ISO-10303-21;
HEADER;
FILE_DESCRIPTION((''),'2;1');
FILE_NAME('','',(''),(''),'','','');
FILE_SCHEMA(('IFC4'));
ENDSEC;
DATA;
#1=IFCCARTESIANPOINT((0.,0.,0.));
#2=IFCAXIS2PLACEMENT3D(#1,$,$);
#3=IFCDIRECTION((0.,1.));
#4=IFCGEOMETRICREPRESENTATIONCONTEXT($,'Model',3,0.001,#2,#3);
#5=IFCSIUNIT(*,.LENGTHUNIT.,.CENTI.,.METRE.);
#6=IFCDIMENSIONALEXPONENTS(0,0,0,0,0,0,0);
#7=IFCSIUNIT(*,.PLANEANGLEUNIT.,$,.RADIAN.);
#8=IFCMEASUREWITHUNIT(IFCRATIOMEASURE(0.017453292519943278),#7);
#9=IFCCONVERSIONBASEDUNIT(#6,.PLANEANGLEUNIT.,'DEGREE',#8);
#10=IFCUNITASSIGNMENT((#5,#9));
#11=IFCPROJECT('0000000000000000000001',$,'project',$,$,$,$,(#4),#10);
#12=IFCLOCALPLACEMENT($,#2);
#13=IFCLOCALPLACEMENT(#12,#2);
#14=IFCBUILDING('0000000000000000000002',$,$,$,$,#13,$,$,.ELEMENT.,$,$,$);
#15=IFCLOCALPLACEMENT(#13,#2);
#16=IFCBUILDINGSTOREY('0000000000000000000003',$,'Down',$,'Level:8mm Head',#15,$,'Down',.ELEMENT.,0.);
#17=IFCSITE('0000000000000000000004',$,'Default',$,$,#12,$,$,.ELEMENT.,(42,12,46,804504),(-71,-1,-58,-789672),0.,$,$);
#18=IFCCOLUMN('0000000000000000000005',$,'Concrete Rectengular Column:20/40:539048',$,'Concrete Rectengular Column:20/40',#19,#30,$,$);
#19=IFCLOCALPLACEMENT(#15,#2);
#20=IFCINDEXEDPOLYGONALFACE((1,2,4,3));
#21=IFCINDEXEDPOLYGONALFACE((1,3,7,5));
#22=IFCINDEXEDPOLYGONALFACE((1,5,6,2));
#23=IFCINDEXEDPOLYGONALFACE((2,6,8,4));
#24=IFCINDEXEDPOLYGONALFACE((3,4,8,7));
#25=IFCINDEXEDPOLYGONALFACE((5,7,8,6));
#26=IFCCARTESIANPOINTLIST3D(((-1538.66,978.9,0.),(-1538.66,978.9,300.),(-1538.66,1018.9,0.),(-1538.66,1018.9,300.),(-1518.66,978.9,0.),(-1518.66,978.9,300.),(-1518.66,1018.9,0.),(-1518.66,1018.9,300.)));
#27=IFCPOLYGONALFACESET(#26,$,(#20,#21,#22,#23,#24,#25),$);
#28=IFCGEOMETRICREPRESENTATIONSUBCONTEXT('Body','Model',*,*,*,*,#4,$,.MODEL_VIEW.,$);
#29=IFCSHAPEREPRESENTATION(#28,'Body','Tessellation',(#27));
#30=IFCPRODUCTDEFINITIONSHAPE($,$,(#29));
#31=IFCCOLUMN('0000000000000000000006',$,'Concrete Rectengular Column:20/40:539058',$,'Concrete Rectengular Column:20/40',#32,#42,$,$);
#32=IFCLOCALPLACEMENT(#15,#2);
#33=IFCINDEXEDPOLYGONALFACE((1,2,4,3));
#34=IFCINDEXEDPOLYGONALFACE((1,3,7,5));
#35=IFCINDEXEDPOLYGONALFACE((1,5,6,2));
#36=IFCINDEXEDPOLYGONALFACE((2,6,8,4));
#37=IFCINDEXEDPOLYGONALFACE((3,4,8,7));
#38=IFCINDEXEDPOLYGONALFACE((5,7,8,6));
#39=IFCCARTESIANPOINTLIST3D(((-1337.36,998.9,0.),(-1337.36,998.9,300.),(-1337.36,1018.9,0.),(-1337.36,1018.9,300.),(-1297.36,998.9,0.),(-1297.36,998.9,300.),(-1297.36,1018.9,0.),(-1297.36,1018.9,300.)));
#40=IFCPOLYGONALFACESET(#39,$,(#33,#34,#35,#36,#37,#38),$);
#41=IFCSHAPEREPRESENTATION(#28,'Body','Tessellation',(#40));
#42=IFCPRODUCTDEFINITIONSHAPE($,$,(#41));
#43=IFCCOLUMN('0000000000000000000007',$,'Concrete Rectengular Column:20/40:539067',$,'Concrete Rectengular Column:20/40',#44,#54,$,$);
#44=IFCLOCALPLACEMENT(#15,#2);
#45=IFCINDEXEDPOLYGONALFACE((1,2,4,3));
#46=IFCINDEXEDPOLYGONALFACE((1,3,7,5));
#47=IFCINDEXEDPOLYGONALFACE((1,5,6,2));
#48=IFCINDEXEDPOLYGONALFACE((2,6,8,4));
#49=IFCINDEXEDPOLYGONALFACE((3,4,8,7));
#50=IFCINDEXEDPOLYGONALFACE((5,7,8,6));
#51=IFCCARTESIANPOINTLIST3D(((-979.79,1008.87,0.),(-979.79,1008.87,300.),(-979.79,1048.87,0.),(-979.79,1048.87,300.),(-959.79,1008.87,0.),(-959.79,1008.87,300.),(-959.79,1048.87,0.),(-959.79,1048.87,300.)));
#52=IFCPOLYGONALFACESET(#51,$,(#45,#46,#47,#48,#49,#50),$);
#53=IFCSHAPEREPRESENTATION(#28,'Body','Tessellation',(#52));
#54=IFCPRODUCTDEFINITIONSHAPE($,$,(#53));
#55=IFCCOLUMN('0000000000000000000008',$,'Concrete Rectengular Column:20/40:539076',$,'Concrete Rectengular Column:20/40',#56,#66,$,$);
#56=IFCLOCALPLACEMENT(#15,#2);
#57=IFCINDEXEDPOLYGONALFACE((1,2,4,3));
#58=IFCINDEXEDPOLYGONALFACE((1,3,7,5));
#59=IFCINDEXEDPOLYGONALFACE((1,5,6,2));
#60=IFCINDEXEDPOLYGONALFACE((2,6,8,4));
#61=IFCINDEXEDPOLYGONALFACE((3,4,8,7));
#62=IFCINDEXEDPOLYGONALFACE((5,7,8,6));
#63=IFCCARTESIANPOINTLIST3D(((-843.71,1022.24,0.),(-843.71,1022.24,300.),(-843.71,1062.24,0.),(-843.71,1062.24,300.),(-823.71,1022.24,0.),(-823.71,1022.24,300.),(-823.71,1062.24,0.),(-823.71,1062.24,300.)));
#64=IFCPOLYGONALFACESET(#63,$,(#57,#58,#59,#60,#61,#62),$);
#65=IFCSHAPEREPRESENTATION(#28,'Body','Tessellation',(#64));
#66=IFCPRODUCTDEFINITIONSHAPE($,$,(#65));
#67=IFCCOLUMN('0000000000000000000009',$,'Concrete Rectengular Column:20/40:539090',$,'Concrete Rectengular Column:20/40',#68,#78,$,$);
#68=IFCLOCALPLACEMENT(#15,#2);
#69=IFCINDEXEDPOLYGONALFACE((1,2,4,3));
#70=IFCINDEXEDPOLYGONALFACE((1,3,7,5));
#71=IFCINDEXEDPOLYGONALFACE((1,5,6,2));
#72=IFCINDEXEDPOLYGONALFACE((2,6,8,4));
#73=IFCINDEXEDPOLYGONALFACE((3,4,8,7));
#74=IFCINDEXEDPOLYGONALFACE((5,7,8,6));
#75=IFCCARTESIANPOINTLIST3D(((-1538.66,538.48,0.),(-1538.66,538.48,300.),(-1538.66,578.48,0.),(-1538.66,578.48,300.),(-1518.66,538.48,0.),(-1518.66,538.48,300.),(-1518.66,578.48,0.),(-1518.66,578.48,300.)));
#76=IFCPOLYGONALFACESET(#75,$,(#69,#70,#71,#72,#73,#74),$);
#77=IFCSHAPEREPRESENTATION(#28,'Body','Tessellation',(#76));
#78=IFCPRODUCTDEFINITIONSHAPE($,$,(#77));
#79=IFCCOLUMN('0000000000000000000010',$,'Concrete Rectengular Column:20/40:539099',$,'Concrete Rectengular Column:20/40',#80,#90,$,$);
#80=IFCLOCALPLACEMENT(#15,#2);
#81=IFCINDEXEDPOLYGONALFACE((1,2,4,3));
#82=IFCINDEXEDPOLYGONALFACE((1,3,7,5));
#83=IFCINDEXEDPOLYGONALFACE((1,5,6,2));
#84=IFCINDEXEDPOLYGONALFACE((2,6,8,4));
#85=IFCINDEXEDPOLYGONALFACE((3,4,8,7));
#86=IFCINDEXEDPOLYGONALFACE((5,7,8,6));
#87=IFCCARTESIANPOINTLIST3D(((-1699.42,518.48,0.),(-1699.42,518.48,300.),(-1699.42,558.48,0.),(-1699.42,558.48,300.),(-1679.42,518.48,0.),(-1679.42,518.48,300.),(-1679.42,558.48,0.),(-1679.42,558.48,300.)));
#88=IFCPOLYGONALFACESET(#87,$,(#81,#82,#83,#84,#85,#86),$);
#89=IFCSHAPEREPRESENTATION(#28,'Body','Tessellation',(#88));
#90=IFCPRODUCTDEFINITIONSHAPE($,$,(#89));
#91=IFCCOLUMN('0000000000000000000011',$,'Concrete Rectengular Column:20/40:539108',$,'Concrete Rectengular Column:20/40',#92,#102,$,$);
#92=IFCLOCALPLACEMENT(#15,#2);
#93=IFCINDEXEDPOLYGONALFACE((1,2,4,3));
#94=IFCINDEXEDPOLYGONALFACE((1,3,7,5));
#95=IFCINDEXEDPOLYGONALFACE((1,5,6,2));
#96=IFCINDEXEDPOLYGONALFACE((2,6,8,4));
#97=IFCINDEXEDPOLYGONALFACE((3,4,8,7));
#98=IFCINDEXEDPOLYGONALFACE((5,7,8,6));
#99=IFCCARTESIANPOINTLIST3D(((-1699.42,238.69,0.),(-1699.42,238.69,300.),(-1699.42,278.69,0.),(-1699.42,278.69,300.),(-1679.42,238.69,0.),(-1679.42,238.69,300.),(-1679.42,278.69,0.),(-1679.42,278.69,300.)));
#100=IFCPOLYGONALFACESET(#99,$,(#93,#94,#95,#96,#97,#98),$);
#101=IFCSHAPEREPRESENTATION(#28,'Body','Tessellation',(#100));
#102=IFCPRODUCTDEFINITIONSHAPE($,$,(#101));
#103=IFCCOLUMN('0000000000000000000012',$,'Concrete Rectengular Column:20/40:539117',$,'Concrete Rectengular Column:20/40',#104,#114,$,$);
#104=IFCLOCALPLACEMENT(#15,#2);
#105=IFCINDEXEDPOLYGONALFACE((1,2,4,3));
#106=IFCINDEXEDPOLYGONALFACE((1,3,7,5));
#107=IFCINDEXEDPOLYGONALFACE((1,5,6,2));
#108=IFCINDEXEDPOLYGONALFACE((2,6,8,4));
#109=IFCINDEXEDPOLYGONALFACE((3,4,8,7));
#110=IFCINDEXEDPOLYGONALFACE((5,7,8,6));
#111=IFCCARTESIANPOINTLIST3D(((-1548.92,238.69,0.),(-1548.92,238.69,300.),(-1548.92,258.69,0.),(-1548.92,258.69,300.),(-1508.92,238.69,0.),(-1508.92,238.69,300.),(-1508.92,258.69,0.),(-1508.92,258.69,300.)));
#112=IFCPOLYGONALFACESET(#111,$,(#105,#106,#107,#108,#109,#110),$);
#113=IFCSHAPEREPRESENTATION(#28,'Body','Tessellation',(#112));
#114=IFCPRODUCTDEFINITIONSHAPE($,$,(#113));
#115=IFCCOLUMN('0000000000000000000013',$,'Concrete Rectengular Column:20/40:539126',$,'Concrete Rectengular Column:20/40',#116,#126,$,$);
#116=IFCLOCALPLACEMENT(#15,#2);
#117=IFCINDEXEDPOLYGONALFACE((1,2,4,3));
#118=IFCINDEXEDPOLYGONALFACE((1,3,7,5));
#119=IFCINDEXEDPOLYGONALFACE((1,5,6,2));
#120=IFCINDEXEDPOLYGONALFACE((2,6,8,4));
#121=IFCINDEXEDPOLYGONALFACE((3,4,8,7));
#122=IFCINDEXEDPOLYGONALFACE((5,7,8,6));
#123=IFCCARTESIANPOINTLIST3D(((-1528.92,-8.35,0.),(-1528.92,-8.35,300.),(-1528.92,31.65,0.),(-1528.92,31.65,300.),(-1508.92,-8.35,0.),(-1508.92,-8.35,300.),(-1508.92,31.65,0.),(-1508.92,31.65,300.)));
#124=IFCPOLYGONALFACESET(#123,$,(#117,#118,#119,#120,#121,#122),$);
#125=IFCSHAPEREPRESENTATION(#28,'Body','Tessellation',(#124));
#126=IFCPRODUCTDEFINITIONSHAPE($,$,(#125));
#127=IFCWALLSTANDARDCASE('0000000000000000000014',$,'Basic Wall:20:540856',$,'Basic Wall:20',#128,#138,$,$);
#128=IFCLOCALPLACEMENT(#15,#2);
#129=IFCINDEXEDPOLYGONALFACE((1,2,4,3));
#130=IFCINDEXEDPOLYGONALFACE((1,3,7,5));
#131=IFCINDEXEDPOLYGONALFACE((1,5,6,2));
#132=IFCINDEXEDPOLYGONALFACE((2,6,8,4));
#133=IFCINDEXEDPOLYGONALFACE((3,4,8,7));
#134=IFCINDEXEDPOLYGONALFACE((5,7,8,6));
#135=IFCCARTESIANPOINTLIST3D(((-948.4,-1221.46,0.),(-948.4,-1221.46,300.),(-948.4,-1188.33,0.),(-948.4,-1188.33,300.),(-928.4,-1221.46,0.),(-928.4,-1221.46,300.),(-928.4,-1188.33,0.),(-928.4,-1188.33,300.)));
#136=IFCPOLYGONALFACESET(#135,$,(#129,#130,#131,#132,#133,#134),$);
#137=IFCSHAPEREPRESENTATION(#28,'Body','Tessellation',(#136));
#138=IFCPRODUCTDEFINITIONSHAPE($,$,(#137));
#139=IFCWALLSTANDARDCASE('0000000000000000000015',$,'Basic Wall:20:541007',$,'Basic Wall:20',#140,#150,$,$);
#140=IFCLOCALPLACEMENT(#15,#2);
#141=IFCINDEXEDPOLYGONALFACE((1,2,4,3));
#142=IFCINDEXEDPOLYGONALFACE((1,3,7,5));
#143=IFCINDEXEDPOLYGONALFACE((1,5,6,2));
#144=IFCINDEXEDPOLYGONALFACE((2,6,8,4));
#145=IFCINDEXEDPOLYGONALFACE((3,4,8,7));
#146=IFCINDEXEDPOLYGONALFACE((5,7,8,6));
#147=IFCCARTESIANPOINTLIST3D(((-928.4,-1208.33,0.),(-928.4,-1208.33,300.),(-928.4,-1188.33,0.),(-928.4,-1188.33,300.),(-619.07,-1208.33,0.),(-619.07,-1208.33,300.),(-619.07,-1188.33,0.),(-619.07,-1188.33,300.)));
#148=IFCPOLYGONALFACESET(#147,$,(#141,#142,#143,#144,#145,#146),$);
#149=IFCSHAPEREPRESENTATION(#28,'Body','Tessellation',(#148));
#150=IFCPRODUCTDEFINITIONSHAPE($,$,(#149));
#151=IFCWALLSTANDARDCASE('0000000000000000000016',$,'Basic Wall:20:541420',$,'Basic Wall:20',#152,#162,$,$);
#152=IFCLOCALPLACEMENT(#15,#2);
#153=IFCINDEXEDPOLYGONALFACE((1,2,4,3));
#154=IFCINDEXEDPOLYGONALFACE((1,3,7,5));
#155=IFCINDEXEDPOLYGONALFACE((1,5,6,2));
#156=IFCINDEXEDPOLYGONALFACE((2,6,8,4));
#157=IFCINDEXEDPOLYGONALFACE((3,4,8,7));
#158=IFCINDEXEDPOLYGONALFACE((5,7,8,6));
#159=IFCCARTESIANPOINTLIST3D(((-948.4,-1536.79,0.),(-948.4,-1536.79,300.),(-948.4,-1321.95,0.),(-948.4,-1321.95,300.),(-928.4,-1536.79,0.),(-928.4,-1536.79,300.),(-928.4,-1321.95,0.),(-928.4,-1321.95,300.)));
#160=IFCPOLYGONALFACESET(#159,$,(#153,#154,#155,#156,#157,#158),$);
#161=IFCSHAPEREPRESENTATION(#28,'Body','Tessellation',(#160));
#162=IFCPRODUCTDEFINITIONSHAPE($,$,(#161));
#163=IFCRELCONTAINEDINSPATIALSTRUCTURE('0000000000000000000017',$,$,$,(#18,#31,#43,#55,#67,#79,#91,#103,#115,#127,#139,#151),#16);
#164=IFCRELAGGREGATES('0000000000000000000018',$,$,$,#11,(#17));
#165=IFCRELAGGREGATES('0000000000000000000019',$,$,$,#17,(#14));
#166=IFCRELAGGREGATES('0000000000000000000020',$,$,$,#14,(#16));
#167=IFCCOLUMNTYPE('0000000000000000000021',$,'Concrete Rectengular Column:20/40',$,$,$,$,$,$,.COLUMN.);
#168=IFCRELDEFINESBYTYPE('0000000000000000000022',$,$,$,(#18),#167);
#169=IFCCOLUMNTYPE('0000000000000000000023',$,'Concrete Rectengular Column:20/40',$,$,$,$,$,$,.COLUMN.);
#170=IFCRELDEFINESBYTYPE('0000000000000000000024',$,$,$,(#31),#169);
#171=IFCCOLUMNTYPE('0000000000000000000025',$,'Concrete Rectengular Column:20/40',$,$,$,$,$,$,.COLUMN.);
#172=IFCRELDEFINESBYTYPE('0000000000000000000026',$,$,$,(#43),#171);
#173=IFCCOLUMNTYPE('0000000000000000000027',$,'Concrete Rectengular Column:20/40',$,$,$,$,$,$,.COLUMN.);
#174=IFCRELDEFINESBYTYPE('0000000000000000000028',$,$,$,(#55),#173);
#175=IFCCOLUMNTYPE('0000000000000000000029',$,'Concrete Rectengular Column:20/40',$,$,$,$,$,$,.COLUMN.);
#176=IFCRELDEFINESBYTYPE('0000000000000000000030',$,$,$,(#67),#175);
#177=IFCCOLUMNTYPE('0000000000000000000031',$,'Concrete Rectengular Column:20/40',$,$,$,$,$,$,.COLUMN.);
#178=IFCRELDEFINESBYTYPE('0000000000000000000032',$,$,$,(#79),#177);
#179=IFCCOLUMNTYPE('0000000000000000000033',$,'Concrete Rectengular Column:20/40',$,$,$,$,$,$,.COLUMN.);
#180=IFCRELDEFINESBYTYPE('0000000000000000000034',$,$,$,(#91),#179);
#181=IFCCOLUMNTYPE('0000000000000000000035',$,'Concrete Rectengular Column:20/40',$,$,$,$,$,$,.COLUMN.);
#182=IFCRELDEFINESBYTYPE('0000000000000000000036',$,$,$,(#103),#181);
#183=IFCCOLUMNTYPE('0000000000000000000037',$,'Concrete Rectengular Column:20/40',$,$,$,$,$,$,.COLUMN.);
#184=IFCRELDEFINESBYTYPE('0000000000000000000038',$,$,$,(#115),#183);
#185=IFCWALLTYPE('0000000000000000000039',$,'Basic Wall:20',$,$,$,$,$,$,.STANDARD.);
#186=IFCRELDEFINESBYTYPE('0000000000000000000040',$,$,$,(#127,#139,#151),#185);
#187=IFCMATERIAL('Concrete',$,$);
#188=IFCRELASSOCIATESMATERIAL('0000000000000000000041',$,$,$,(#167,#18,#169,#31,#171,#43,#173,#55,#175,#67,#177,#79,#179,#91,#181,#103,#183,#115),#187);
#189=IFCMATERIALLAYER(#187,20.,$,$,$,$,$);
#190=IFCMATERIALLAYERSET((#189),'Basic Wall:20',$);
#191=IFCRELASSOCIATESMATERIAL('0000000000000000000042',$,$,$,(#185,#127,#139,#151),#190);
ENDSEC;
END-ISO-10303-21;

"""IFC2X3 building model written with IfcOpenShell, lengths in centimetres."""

from ifc_helpers import new_model, entity, si_unit, converted_unit, direction, frame, frame_2d, origin, origin_2d_with_axis, place, context, subcontext, project, spatial, rectangle, extrude, source, transform, mapped, material, layer, layer_set, layer_usage, type_object, type_shapes, element, save


model = new_model("IFC2X3")

# Units and contexts
model_context = context("Model", 3, precision=0.001, world=origin(), true_north=direction((0.0, 1.0)))
body_context = subcontext(model_context, "Body", "Model", "MODEL_VIEW")
ifc_project = project(units=[si_unit("LENGTHUNIT", "METRE", prefix="CENTI"), converted_unit("PLANEANGLEUNIT", "DEGREE", entity("IfcRatioMeasure", 0.017453292519943278), si_unit("PLANEANGLEUNIT", "RADIAN"), dimensions=[0, 0, 0, 0, 0, 0, 0])], contexts=[model_context])

# Site, building, storey
site_placement = place(None, origin())
site = spatial("IfcSite", under=ifc_project, at=site_placement, Name="Default", CompositionType="ELEMENT", RefLatitude=(42, 12, 46, 804504), RefLongitude=(-71, -1, -58, -789672), RefElevation=0.0)
building_placement = place(site_placement, origin())
building = spatial("IfcBuilding", under=site, at=building_placement, CompositionType="ELEMENT")
storey_placement = place(building_placement, origin())
storey = spatial("IfcBuildingStorey", under=building, at=storey_placement, Name="Down", ObjectType="Level:8mm Head", LongName="Down", CompositionType="ELEMENT", Elevation=0.0)

# Columns
ifc_material = material(Name="Concrete")
column_type_1 = type_object("IfcColumnType", Name="Concrete Rectengular Column:20/40", PredefinedType="COLUMN", material=ifc_material)
shared_shape_1 = source(origin(), body_context, "Body", "SweptSolid", [
    extrude(rectangle(XDim=40.0, YDim=20.0, at=frame_2d((0.0, 0.0), x_axis=(1.0, 0.0))), frame((-1528.66, 998.9, 0.0), z_axis=(0.0, 0.0, 1.0), x_axis=(0.0, -1.0, 0.0)), (0.0, 0.0, 1.0), 300.0),
])
type_shapes(column_type_1, [shared_shape_1])
column_1_placement = place(storey_placement, origin())
element("IfcColumn", 1, at=column_1_placement, inside=storey, type_object=column_type_1, material=ifc_material, Name="Concrete Rectengular Column:20/40:539048", ObjectType="Concrete Rectengular Column:20/40", context=body_context, shape_type="MappedRepresentation", body=[
    mapped(shared_shape_1, transform((0.0, 0.0, 0.0), scale=1.0)),
])
column_type_2 = type_object("IfcColumnType", Name="Concrete Rectengular Column:20/40", PredefinedType="COLUMN", material=ifc_material)
shared_shape_2 = source(origin(), body_context, "Body", "SweptSolid", [
    extrude(rectangle(XDim=20.0, YDim=40.0, at=frame_2d((0.0, 0.0), x_axis=(1.0, 0.0))), frame((-1317.36, 1008.9, 0.0), z_axis=(0.0, 0.0, 1.0), x_axis=(0.0, -1.0, 0.0)), (0.0, 0.0, 1.0), 300.0),
])
type_shapes(column_type_2, [shared_shape_2])
column_2_placement = place(storey_placement, origin())
element("IfcColumn", 2, at=column_2_placement, inside=storey, type_object=column_type_2, material=ifc_material, Name="Concrete Rectengular Column:20/40:539058", ObjectType="Concrete Rectengular Column:20/40", context=body_context, shape_type="MappedRepresentation", body=[
    mapped(shared_shape_2, transform((0.0, 0.0, 0.0), scale=1.0)),
])
column_type_3 = type_object("IfcColumnType", Name="Concrete Rectengular Column:20/40", PredefinedType="COLUMN", material=ifc_material)
shared_shape_3 = source(origin(), body_context, "Body", "SweptSolid", [
    extrude(rectangle(XDim=40.0, YDim=20.0, at=frame_2d((0.0, 0.0), x_axis=(1.0, 0.0))), frame((-969.79, 1028.87, 0.0), z_axis=(0.0, 0.0, 1.0), x_axis=(0.0, -1.0, 0.0)), (0.0, 0.0, 1.0), 300.0),
])
type_shapes(column_type_3, [shared_shape_3])
column_3_placement = place(storey_placement, origin())
element("IfcColumn", 3, at=column_3_placement, inside=storey, type_object=column_type_3, material=ifc_material, Name="Concrete Rectengular Column:20/40:539067", ObjectType="Concrete Rectengular Column:20/40", context=body_context, shape_type="MappedRepresentation", body=[
    mapped(shared_shape_3, transform((0.0, 0.0, 0.0), scale=1.0)),
])
column_type_4 = type_object("IfcColumnType", Name="Concrete Rectengular Column:20/40", PredefinedType="COLUMN", material=ifc_material)
shared_shape_4 = source(origin(), body_context, "Body", "SweptSolid", [
    extrude(rectangle(XDim=40.0, YDim=20.0, at=origin_2d_with_axis()), frame((-833.71, 1042.24, 0.0), z_axis=(0.0, 0.0, 1.0), x_axis=(0.0, -1.0, 0.0)), (0.0, 0.0, 1.0), 300.0),
])
type_shapes(column_type_4, [shared_shape_4])
column_4_placement = place(storey_placement, origin())
element("IfcColumn", 4, at=column_4_placement, inside=storey, type_object=column_type_4, material=ifc_material, Name="Concrete Rectengular Column:20/40:539076", ObjectType="Concrete Rectengular Column:20/40", context=body_context, shape_type="MappedRepresentation", body=[
    mapped(shared_shape_4, transform((0.0, 0.0, 0.0), scale=1.0)),
])
column_type_5 = type_object("IfcColumnType", Name="Concrete Rectengular Column:20/40", PredefinedType="COLUMN", material=ifc_material)
shared_shape_5 = source(origin(), body_context, "Body", "SweptSolid", [
    extrude(rectangle(XDim=40.0, YDim=20.0, at=frame_2d((0.0, 0.0), x_axis=(1.0, 0.0))), frame((-1528.66, 558.48, 0.0), z_axis=(0.0, 0.0, 1.0), x_axis=(0.0, -1.0, 0.0)), (0.0, 0.0, 1.0), 300.0),
])
type_shapes(column_type_5, [shared_shape_5])
column_5_placement = place(storey_placement, origin())
element("IfcColumn", 5, at=column_5_placement, inside=storey, type_object=column_type_5, material=ifc_material, Name="Concrete Rectengular Column:20/40:539090", ObjectType="Concrete Rectengular Column:20/40", context=body_context, shape_type="MappedRepresentation", body=[
    mapped(shared_shape_5, transform((0.0, 0.0, 0.0), scale=1.0)),
])
column_type_6 = type_object("IfcColumnType", Name="Concrete Rectengular Column:20/40", PredefinedType="COLUMN", material=ifc_material)
shared_shape_6 = source(origin(), body_context, "Body", "SweptSolid", [
    extrude(rectangle(XDim=40.0, YDim=20.0, at=frame_2d((0.0, 0.0), x_axis=(1.0, 0.0))), frame((-1689.42, 538.48, 0.0), z_axis=(0.0, 0.0, 1.0), x_axis=(0.0, -1.0, 0.0)), (0.0, 0.0, 1.0), 300.0),
])
type_shapes(column_type_6, [shared_shape_6])
column_6_placement = place(storey_placement, origin())
element("IfcColumn", 6, at=column_6_placement, inside=storey, type_object=column_type_6, material=ifc_material, Name="Concrete Rectengular Column:20/40:539099", ObjectType="Concrete Rectengular Column:20/40", context=body_context, shape_type="MappedRepresentation", body=[
    mapped(shared_shape_6, transform((0.0, 0.0, 0.0), scale=1.0)),
])
column_type_7 = type_object("IfcColumnType", Name="Concrete Rectengular Column:20/40", PredefinedType="COLUMN", material=ifc_material)
shared_shape_7 = source(origin(), body_context, "Body", "SweptSolid", [
    extrude(rectangle(XDim=40.0, YDim=20.0, at=frame_2d((0.0, 0.0), x_axis=(1.0, 0.0))), frame((-1689.42, 258.69, 0.0), z_axis=(0.0, 0.0, 1.0), x_axis=(0.0, -1.0, 0.0)), (0.0, 0.0, 1.0), 300.0),
])
type_shapes(column_type_7, [shared_shape_7])
column_7_placement = place(storey_placement, origin())
element("IfcColumn", 7, at=column_7_placement, inside=storey, type_object=column_type_7, material=ifc_material, Name="Concrete Rectengular Column:20/40:539108", ObjectType="Concrete Rectengular Column:20/40", context=body_context, shape_type="MappedRepresentation", body=[
    mapped(shared_shape_7, transform((0.0, 0.0, 0.0), scale=1.0)),
])
column_type_8 = type_object("IfcColumnType", Name="Concrete Rectengular Column:20/40", PredefinedType="COLUMN", material=ifc_material)
shared_shape_8 = source(origin(), body_context, "Body", "SweptSolid", [
    extrude(rectangle(XDim=20.0, YDim=40.0, at=frame_2d((0.0, 0.0), x_axis=(1.0, 0.0))), frame((-1528.92, 248.69, 0.0), z_axis=(0.0, 0.0, 1.0), x_axis=(0.0, -1.0, 0.0)), (0.0, 0.0, 1.0), 300.0),
])
type_shapes(column_type_8, [shared_shape_8])
column_8_placement = place(storey_placement, origin())
element("IfcColumn", 8, at=column_8_placement, inside=storey, type_object=column_type_8, material=ifc_material, Name="Concrete Rectengular Column:20/40:539117", ObjectType="Concrete Rectengular Column:20/40", context=body_context, shape_type="MappedRepresentation", body=[
    mapped(shared_shape_8, transform((0.0, 0.0, 0.0), scale=1.0)),
])
column_type_9 = type_object("IfcColumnType", Name="Concrete Rectengular Column:20/40", PredefinedType="COLUMN", material=ifc_material)
shared_shape_9 = source(origin(), body_context, "Body", "SweptSolid", [
    extrude(rectangle(XDim=40.0, YDim=20.0, at=frame_2d((0.0, 0.0), x_axis=(1.0, 0.0))), frame((-1518.92, 11.65, 0.0), z_axis=(0.0, 0.0, 1.0), x_axis=(0.0, -1.0, 0.0)), (0.0, 0.0, 1.0), 300.0),
])
type_shapes(column_type_9, [shared_shape_9])
column_9_placement = place(storey_placement, origin())
element("IfcColumn", 9, at=column_9_placement, inside=storey, type_object=column_type_9, material=ifc_material, Name="Concrete Rectengular Column:20/40:539126", ObjectType="Concrete Rectengular Column:20/40", context=body_context, shape_type="MappedRepresentation", body=[
    mapped(shared_shape_9, transform((0.0, 0.0, 0.0), scale=1.0)),
])

# Walls
ifc_layer_1 = layer(ifc_material, 20.0)
ifc_layer_set_1 = layer_set([ifc_layer_1], Name="Basic Wall:20")
ifc_layer_usage_1 = layer_usage(ifc_layer_set_1, "AXIS2", "NEGATIVE", 10.0)
wall_type_1 = type_object("IfcWallType", Name="Basic Wall:20", PredefinedType="STANDARD", material=ifc_layer_set_1)
wall_1_placement = place(storey_placement, frame((-938.4, -1221.46, 0.0), z_axis=(0.0, 0.0, 1.0), x_axis=(0.0, 1.0, 0.0)))
element("IfcWallStandardCase", 10, at=wall_1_placement, inside=storey, type_object=wall_type_1, material=ifc_layer_usage_1, Name="Basic Wall:20:540856", ObjectType="Basic Wall:20", context=body_context, shape_type="SweptSolid", body=[
    extrude(rectangle(XDim=33.13, YDim=20.0, at=frame_2d((16.56, 0.0), x_axis=(-1.0, 0.0))), origin(), (0.0, 0.0, 1.0), 300.0),
])
ifc_layer_usage_2 = layer_usage(ifc_layer_set_1, "AXIS2", "NEGATIVE", 10.0)
wall_2_placement = place(storey_placement, frame((-928.4, -1198.33, 0.0)))
element("IfcWallStandardCase", 11, at=wall_2_placement, inside=storey, type_object=wall_type_1, material=ifc_layer_usage_2, Name="Basic Wall:20:541007", ObjectType="Basic Wall:20", context=body_context, shape_type="SweptSolid", body=[
    extrude(rectangle(XDim=309.33, YDim=20.0, at=frame_2d((154.67, 0.0), x_axis=(-1.0, 0.0))), origin(), (0.0, 0.0, 1.0), 300.0),
])
ifc_layer_usage_3 = layer_usage(ifc_layer_set_1, "AXIS2", "NEGATIVE", 10.0)
wall_3_placement = place(storey_placement, frame((-938.4, -1536.79, 0.0), z_axis=(0.0, 0.0, 1.0), x_axis=(0.0, 1.0, 0.0)))
element("IfcWallStandardCase", 12, at=wall_3_placement, inside=storey, type_object=wall_type_1, material=ifc_layer_usage_3, Name="Basic Wall:20:541420", ObjectType="Basic Wall:20", context=body_context, shape_type="SweptSolid", body=[
    extrude(rectangle(XDim=214.85, YDim=20.0, at=frame_2d((107.42, 0.0), x_axis=(-1.0, 0.0))), origin(), (0.0, 0.0, 1.0), 300.0),
])

save(model, "model.ifc")
